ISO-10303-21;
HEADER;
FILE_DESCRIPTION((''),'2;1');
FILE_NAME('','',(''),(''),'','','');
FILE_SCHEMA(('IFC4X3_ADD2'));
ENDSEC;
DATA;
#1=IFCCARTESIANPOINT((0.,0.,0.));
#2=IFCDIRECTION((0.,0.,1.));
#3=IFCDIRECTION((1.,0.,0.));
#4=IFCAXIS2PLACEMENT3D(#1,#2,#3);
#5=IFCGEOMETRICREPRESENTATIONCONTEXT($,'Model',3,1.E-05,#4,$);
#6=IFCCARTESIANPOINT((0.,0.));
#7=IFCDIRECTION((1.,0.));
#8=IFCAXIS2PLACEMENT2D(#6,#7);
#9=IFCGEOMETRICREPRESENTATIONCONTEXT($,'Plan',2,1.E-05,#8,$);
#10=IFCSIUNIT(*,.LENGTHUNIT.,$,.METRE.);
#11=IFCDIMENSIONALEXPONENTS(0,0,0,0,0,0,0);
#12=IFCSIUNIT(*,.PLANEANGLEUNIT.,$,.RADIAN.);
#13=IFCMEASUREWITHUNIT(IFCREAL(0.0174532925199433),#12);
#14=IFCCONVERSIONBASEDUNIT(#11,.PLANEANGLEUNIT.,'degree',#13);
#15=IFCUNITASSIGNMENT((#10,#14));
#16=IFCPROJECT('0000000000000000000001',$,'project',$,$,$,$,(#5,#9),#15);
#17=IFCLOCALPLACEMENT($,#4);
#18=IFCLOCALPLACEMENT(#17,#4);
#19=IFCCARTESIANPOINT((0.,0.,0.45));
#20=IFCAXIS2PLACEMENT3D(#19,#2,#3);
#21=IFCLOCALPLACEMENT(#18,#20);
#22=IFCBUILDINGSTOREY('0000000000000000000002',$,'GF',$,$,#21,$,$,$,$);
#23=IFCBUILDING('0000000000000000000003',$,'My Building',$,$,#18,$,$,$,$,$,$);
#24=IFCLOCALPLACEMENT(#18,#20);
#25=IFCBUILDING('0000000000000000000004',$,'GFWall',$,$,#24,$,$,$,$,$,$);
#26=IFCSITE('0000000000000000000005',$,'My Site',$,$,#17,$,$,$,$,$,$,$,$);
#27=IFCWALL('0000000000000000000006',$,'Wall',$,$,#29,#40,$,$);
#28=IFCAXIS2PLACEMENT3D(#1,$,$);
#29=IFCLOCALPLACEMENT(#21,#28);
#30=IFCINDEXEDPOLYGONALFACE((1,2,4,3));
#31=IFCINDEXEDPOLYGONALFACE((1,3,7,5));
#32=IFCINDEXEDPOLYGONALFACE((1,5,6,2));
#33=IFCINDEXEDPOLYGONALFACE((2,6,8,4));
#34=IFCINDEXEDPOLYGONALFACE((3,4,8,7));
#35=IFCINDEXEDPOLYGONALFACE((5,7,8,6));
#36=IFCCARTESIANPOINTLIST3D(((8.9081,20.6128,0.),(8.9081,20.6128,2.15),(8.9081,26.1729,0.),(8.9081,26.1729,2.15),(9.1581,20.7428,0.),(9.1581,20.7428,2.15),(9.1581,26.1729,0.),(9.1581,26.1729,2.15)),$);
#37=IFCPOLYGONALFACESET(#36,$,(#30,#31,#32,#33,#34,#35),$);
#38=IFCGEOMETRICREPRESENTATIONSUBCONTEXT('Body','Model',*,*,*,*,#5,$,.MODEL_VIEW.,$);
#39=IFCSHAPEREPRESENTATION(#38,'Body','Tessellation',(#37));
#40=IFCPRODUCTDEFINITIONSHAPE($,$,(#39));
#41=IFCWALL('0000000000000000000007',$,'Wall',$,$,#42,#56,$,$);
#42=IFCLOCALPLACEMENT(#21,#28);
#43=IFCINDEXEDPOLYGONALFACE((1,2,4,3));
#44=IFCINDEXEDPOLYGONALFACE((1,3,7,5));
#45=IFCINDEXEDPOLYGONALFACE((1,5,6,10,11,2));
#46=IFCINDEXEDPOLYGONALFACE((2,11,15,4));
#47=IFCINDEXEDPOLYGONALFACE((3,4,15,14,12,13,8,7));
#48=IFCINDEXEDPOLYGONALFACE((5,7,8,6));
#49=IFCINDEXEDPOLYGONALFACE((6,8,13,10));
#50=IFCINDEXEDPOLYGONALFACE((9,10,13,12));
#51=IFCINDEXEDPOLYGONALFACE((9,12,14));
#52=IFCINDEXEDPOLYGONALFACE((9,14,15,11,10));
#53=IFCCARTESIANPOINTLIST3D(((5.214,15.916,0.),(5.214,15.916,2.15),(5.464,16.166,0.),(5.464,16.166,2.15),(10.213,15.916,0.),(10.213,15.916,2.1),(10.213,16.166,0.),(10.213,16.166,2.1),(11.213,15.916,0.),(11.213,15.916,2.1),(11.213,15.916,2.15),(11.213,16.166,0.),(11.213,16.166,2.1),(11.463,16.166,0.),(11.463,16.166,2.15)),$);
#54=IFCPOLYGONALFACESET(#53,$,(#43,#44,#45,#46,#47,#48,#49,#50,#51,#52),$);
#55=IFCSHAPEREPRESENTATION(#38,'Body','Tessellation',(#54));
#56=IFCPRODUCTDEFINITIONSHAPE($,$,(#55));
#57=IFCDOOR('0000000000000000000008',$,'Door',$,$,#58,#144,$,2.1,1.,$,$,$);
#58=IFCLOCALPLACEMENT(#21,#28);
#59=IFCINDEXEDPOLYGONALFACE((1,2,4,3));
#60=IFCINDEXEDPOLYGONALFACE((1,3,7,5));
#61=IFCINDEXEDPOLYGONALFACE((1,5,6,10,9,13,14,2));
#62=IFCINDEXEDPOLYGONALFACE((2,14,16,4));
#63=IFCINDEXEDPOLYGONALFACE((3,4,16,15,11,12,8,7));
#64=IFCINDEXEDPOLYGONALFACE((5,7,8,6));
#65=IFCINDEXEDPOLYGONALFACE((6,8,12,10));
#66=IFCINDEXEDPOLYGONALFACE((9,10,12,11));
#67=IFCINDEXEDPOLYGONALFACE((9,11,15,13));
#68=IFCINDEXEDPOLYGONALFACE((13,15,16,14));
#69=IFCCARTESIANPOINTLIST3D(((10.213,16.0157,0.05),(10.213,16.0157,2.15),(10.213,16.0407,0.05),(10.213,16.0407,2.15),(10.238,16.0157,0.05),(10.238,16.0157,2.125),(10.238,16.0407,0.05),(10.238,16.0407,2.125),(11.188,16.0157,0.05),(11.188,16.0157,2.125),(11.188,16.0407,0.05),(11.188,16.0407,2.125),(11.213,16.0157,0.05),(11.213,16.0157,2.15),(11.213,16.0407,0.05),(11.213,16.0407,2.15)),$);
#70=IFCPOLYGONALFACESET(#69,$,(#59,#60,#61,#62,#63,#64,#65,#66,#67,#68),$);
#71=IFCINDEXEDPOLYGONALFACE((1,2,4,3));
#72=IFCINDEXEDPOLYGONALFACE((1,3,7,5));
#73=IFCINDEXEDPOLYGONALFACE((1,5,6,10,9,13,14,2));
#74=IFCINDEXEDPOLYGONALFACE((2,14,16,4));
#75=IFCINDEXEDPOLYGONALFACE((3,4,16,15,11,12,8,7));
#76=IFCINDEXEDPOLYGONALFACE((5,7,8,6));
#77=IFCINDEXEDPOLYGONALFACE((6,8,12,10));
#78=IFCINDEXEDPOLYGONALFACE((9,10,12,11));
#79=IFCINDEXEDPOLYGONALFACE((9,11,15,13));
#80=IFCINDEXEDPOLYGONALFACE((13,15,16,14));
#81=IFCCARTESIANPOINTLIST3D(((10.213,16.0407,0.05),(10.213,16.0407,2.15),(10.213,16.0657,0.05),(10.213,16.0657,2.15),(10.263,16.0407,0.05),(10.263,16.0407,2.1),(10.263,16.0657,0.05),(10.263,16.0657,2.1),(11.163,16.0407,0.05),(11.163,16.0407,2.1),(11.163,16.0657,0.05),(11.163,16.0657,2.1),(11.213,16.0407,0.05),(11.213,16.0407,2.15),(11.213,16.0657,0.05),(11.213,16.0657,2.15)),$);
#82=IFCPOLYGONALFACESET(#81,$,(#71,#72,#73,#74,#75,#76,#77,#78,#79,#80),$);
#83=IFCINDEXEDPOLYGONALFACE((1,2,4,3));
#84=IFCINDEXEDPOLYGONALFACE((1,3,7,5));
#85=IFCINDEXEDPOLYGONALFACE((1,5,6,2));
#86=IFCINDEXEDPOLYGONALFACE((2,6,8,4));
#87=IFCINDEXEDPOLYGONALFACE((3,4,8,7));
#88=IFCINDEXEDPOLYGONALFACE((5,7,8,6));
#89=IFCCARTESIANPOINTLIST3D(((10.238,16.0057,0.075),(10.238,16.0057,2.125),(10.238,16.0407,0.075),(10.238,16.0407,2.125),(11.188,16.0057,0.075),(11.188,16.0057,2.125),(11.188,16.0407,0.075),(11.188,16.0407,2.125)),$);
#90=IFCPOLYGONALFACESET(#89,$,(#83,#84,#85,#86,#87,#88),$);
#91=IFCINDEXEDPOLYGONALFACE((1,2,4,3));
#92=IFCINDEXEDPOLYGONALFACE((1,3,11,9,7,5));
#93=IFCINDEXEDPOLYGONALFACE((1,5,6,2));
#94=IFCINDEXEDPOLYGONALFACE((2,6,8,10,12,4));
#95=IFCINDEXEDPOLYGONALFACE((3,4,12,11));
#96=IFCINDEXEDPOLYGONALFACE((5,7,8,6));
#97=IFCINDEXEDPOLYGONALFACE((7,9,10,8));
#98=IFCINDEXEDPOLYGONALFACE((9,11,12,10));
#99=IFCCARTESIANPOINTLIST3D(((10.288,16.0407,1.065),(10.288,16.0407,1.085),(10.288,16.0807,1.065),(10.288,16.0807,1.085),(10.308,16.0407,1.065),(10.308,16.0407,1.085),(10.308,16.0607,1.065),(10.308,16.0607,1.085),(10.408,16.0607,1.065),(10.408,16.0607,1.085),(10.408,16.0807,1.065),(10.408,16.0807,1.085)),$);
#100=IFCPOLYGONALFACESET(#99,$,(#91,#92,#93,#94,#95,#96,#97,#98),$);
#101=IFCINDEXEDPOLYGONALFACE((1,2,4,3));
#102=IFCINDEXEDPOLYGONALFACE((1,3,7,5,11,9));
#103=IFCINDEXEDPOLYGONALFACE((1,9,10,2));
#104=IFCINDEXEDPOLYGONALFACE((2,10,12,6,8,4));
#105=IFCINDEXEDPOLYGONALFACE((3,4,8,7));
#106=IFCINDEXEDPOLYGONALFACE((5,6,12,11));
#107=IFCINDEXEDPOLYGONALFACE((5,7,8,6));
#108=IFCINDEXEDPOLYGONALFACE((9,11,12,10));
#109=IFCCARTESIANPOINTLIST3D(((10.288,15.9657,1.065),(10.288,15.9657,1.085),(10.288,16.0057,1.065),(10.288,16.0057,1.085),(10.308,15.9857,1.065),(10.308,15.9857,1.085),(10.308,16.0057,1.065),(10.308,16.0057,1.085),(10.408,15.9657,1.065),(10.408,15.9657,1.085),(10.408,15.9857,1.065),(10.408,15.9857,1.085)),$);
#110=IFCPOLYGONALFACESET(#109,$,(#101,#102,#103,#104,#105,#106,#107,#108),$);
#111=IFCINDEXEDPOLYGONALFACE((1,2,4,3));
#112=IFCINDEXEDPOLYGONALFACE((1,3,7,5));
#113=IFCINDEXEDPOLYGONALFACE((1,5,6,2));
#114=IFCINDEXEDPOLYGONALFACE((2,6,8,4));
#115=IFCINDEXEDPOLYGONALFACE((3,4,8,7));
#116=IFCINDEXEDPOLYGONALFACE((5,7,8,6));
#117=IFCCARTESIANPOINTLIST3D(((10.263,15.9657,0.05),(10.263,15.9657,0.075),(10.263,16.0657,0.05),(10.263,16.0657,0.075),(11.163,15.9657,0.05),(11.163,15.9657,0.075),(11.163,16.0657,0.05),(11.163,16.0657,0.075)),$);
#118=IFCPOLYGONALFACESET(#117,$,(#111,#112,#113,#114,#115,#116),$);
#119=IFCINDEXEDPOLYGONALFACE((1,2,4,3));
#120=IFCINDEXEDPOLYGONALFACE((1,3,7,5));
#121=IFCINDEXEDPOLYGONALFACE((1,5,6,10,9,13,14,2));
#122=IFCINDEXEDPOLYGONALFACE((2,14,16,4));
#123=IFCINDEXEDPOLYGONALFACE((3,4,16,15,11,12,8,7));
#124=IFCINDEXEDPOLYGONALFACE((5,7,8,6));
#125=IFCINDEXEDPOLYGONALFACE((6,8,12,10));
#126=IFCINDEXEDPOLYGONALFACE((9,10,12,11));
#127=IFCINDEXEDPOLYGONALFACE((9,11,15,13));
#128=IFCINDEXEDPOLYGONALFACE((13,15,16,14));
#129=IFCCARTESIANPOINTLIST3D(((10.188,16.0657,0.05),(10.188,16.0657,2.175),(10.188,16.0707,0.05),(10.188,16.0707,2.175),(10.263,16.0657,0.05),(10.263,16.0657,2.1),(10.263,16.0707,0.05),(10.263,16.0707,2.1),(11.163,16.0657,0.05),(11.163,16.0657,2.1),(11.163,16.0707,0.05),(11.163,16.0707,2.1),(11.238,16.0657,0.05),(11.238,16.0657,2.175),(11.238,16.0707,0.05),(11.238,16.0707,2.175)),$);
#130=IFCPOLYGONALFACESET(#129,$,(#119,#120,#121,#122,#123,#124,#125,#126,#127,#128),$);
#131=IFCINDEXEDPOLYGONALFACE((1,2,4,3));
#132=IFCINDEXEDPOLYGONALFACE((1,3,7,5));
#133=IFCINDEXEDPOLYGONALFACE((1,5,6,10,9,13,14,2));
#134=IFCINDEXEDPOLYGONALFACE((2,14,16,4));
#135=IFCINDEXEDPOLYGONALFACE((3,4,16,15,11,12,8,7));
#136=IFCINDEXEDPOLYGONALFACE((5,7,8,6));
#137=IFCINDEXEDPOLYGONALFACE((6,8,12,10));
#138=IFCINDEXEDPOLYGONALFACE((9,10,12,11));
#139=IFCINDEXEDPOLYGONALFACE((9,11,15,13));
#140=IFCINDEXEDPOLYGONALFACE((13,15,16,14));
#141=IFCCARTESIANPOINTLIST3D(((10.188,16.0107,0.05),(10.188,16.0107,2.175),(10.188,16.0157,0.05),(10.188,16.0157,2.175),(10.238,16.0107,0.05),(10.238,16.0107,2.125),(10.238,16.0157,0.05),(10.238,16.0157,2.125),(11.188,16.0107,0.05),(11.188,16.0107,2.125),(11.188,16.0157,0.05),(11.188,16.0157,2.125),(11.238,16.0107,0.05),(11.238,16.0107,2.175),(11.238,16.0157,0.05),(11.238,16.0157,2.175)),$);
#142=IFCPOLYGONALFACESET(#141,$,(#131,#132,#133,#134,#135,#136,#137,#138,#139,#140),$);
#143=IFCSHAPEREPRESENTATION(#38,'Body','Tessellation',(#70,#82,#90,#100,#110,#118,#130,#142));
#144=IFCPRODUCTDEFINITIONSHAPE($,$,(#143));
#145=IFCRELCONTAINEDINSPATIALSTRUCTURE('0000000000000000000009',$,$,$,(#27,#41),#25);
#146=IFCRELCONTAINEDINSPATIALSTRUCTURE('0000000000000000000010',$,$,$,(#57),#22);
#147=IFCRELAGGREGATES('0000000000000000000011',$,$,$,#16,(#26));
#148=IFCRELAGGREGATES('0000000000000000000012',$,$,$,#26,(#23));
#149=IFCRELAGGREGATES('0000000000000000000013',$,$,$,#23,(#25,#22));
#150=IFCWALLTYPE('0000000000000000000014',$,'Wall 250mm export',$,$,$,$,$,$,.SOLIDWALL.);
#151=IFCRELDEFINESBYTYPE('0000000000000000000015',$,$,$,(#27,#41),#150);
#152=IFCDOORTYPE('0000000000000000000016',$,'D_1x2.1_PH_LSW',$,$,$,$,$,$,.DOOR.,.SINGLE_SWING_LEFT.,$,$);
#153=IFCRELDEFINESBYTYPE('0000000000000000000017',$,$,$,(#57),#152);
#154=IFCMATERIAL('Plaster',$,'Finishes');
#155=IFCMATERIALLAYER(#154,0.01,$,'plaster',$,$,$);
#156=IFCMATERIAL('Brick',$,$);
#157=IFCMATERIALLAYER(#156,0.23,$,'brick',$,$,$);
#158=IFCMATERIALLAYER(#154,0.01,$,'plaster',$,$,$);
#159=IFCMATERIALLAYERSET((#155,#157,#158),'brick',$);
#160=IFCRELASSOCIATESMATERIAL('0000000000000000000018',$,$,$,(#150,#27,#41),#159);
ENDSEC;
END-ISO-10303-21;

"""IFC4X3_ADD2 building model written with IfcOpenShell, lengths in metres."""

from ifc_helpers import new_model, entity, si_unit, converted_unit, frame, origin_with_axes, origin_2d_with_axis, place, context, subcontext, project, spatial, line, indexed_curve, outline, extrude, shape, source, transform, mapped, material, layer, layer_set, layer_usage, type_object, type_shapes, element, fill, save


model = new_model("IFC4X3_ADD2")

# Units and contexts
model_context = context("Model", 3, precision=1e-05, world=origin_with_axes())
plan_context = context("Plan", 2, precision=1e-05, world=origin_2d_with_axis())
body_context_1 = subcontext(model_context, "Body", "Model", "MODEL_VIEW")
body_context_2 = subcontext(plan_context, "Body", "Plan", "PLAN_VIEW")
ifc_project = project(units=[si_unit("LENGTHUNIT", "METRE"), converted_unit("PLANEANGLEUNIT", "degree", entity("IfcReal", 0.0174532925199433), si_unit("PLANEANGLEUNIT", "RADIAN"), dimensions=[0, 0, 0, 0, 0, 0, 0])], contexts=[model_context, plan_context])

# Site, buildings
site_placement = place(None, origin_with_axes())
site = spatial("IfcSite", under=ifc_project, at=site_placement, Name="My Site")
building_1_placement = place(site_placement, origin_with_axes())
building_1 = spatial("IfcBuilding", under=site, at=building_1_placement, Name="My Building")
building_2_placement = place(building_1_placement, frame((0.0, 0.0, 0.45), z_axis=(0.0, 0.0, 1.0), x_axis=(1.0, 0.0, 0.0)))
building_2 = spatial("IfcBuilding", under=building_1, at=building_2_placement, Name="GFWall")

# Shared definitions
ifc_material_1 = material(Name="Plaster", Category="Finishes")
ifc_layer_1 = layer(ifc_material_1, 0.01, Name="plaster")
ifc_material_2 = material(Name="Brick")
ifc_layer_2 = layer(ifc_material_2, 0.23, Name="brick")
ifc_layer_3 = layer(ifc_material_1, 0.01, Name="plaster")
ifc_layer_set = layer_set([ifc_layer_1, ifc_layer_2, ifc_layer_3], Name="brick")
wall_type = type_object("IfcWallType", Name="Wall 250mm export", PredefinedType="SOLIDWALL", material=ifc_layer_set)

# Shared definitions
storey_placement = place(building_1_placement, frame((0.0, 0.0, 0.45), z_axis=(0.0, 0.0, 1.0), x_axis=(1.0, 0.0, 0.0)))
storey = spatial("IfcBuildingStorey", under=building_1, at=storey_placement, Name="GF")

# Wall
ifc_layer_usage_1 = layer_usage(ifc_layer_set, "AXIS2", "POSITIVE", 0.0)
wall_1_placement = place(building_2_placement, frame((9.1581, 20.6128, 0.0), z_axis=(0.0, 0.0, 1.0), x_axis=(0.0, 1.0, 0.0)))
element("IfcWall", 1, at=wall_1_placement, inside=building_2, type_object=wall_type, material=ifc_layer_usage_1, Name="Wall", context=body_context_1, shape_type="SweptSolid", body=[
    extrude(outline(indexed_curve([(0.13, 0.0), (0.0, 0.25), (5.5601, 0.25), (5.5601, 0.0)], segments=[line(1, 2, 3, 4, 1)])), origin_with_axes(), (0.0, 0.0, 1.0), 2.15),
])

# Wall, opening, door
ifc_layer_usage_2 = layer_usage(ifc_layer_set, "AXIS2", "POSITIVE", 0.0)
wall_2_placement = place(building_2_placement, frame((5.464, 15.916, 0.0), z_axis=(0.0, 0.0, 1.0), x_axis=(1.0, 0.0, 0.0)))
wall_2 = element("IfcWall", 2, at=wall_2_placement, inside=building_2, type_object=wall_type, material=ifc_layer_usage_2, Name="Wall", context=body_context_1, shape_type="SweptSolid", body=[
    extrude(outline(indexed_curve([(-0.25, 0.0), (0.0, 0.25), (5.999, 0.25), (5.749, 0.0)], segments=[line(1, 2, 3, 4, 1)])), origin_with_axes(), (0.0, 0.0, 1.0), 2.15),
])
shared_shape_1 = source(origin_with_axes(), body_context_1, "Body", "SweptSolid", [
    extrude(outline(indexed_curve([(0.0, 0.0), (1.0, 0.0), (1.0, 2.1), (0.0, 2.1)], segments=[line(1, 2, 3, 4, 1)])), frame((0.0, -0.6, 0.0), z_axis=(0.0, -1.0, 0.0), x_axis=(1.0, 0.0, 0.0)), (0.0, 0.0, -1.0), 1.2),
])
opening_1_placement = place(wall_2_placement, frame((5.749, 0.1497, 0.0), z_axis=(0.0, 0.0, 1.0), x_axis=(-1.0, 0.0, 0.0)))
opening_1 = element("IfcOpeningElement", 3, at=opening_1_placement, cuts=wall_2, PredefinedType="OPENING", context=body_context_1, shape_type="MappedRepresentation", body=[
    mapped(shared_shape_1, transform((0.0, 0.0, 0.0), x_axis=(1.0, 0.0, 0.0), y_axis=(0.0, 1.0, 0.0), z_axis=(0.0, 0.0, 1.0), scale=1.0)),
])
door_type_1 = type_object("IfcDoorType", Name="D_1x2.1_PH_LSW", OperationType="SINGLE_SWING_LEFT", PredefinedType="DOOR")
shared_shape_2 = source(origin_with_axes(), body_context_1, "Body", "SweptSolid", [
    extrude(outline(indexed_curve([(0.0, 0.0), (0.0, 2.1), (1.0, 2.1), (1.0, 0.0), (0.975, 0.0), (0.975, 2.075), (0.025, 2.075), (0.025, 0.0)], segments=[line(1, 2, 3, 4, 5, 6, 7, 8, 1)])), frame((0.0, 0.025, 0.0), z_axis=(0.0, -1.0, 0.0), x_axis=(1.0, 0.0, 0.0)), (0.0, 0.0, -1.0), 0.025),
    extrude(outline(indexed_curve([(0.0, 0.0), (0.0, 2.1), (1.0, 2.1), (1.0, 0.0), (0.95, 0.0), (0.95, 2.05), (0.05, 2.05), (0.05, 0.0)], segments=[line(1, 2, 3, 4, 5, 6, 7, 8, 1)])), frame((0.0, 0.0, 0.0), z_axis=(0.0, -1.0, 0.0), x_axis=(1.0, 0.0, 0.0)), (0.0, 0.0, -1.0), 0.025),
    extrude(outline(indexed_curve([(0.0, 0.0), (0.95, 0.0), (0.95, 0.035), (0.0, 0.035)], segments=[line(1, 2, 3, 4, 1)])), frame((0.025, 0.025, 0.025), z_axis=(0.0, 0.0, 1.0), x_axis=(1.0, 0.0, 0.0)), (0.0, 0.0, 1.0), 2.05),
    extrude(outline(indexed_curve([(0.0, 0.0), (0.0, -0.04), (-0.12, -0.04), (-0.12, -0.02), (-0.02, -0.02), (-0.02, 0.0)], segments=[line(1, 2, 3, 4, 5, 6, 1)])), frame((0.925, 0.025, 1.015), z_axis=(0.0, 0.0, 1.0), x_axis=(1.0, 0.0, 0.0)), (0.0, 0.0, 1.0), 0.02),
    extrude(outline(indexed_curve([(0.0, 0.0), (0.0, 0.04), (-0.12, 0.04), (-0.12, 0.02), (-0.02, 0.02), (-0.02, 0.0)], segments=[line(1, 2, 3, 4, 5, 6, 1)])), frame((0.925, 0.06, 1.015), z_axis=(0.0, 0.0, 1.0), x_axis=(1.0, 0.0, 0.0)), (0.0, 0.0, 1.0), 0.02),
    extrude(outline(indexed_curve([(0.0, 0.0), (0.9, 0.0), (0.9, 0.1), (0.0, 0.1)], segments=[line(1, 2, 3, 4, 1)])), frame((0.05, 0.0, 0.0), z_axis=(0.0, 0.0, 1.0), x_axis=(1.0, 0.0, 0.0)), (0.0, 0.0, 1.0), 0.025),
    extrude(outline(indexed_curve([(0.0, 0.0), (0.0, 2.125), (1.05, 2.125), (1.05, 0.0), (0.975, 0.0), (0.975, 2.05), (0.075, 2.05), (0.075, 0.0)], segments=[line(1, 2, 3, 4, 5, 6, 7, 8, 1)])), frame((-0.025, -0.005, 0.0), z_axis=(0.0, -1.0, 0.0), x_axis=(1.0, 0.0, 0.0)), (0.0, 0.0, -1.0), 0.005),
    extrude(outline(indexed_curve([(0.0, 0.0), (0.0, 2.125), (1.05, 2.125), (1.05, 0.0), (1.0, 0.0), (1.0, 2.075), (0.05, 2.075), (0.05, 0.0)], segments=[line(1, 2, 3, 4, 5, 6, 7, 8, 1)])), frame((-0.025, 0.05, 0.0), z_axis=(0.0, -1.0, 0.0), x_axis=(1.0, 0.0, 0.0)), (0.0, 0.0, -1.0), 0.005),
])
shared_shape_3 = source(origin_with_axes(), body_context_2, "Body", "Curve2D", [
    entity("IfcIndexedPolyCurve", entity("IfcCartesianPointList2D", [[0.0, 0.0], [0.0, 0.05], [0.025, 0.05], [0.025, 0.025], [0.05, 0.025], [0.05, 0.0]]), [entity("IfcLineIndex", [1, 2, 3, 4, 5, 6, 1])]),
    entity("IfcIndexedPolyCurve", entity("IfcCartesianPointList2D", [[1.0, 0.0], [1.0, 0.05], [0.975, 0.05], [0.975, 0.025], [0.95, 0.025], [0.95, 0.0]]), [entity("IfcLineIndex", [1, 2, 3, 4, 5, 6, 1])]),
    entity("IfcTrimmedCurve", entity("IfcEllipse", entity("IfcAxis2Placement2D", entity("IfcCartesianPoint", [0.06, 0.05]), entity("IfcDirection", [1.0, 0.0])), 0.915, 0.95), [entity("IfcCartesianPoint", [0.975, 0.05])], [entity("IfcCartesianPoint", [0.06, 1.0])], True, "CARTESIAN"),
    entity("IfcIndexedPolyCurve", entity("IfcCartesianPointList2D", [[0.025, 0.05], [0.06, 0.05], [0.06, 1.0], [0.025, 1.0]]), [entity("IfcLineIndex", [1, 2, 3, 4, 1])]),
])
type_shapes(door_type_1, [shared_shape_2, shared_shape_3])
door_1_placement = place(opening_1_placement, frame((0.0, 0.0, 0.05), z_axis=(0.0, 0.0, 1.0), x_axis=(1.0, 0.0, 0.0)))
door_1 = element("IfcDoor", 4, at=door_1_placement, inside=storey, type_object=door_type_1, Name="Door", OverallHeight=2.1, OverallWidth=1.0, shapes=[
    shape(body_context_1, "Body", "MappedRepresentation", [mapped(shared_shape_2, transform((0.0, 0.0, 0.0), x_axis=(1.0, 0.0, 0.0), y_axis=(0.0, 1.0, 0.0), z_axis=(0.0, 0.0, 1.0), scale=1.0))]),
    shape(body_context_2, "Body", "MappedRepresentation", [mapped(shared_shape_3, transform((0.0, 0.0, 0.0), x_axis=(1.0, 0.0, 0.0), y_axis=(0.0, 1.0, 0.0), z_axis=(0.0, 0.0, 1.0), scale=1.0))]),
])
fill(opening_1, door_1)

save(model, "model.ifc")
